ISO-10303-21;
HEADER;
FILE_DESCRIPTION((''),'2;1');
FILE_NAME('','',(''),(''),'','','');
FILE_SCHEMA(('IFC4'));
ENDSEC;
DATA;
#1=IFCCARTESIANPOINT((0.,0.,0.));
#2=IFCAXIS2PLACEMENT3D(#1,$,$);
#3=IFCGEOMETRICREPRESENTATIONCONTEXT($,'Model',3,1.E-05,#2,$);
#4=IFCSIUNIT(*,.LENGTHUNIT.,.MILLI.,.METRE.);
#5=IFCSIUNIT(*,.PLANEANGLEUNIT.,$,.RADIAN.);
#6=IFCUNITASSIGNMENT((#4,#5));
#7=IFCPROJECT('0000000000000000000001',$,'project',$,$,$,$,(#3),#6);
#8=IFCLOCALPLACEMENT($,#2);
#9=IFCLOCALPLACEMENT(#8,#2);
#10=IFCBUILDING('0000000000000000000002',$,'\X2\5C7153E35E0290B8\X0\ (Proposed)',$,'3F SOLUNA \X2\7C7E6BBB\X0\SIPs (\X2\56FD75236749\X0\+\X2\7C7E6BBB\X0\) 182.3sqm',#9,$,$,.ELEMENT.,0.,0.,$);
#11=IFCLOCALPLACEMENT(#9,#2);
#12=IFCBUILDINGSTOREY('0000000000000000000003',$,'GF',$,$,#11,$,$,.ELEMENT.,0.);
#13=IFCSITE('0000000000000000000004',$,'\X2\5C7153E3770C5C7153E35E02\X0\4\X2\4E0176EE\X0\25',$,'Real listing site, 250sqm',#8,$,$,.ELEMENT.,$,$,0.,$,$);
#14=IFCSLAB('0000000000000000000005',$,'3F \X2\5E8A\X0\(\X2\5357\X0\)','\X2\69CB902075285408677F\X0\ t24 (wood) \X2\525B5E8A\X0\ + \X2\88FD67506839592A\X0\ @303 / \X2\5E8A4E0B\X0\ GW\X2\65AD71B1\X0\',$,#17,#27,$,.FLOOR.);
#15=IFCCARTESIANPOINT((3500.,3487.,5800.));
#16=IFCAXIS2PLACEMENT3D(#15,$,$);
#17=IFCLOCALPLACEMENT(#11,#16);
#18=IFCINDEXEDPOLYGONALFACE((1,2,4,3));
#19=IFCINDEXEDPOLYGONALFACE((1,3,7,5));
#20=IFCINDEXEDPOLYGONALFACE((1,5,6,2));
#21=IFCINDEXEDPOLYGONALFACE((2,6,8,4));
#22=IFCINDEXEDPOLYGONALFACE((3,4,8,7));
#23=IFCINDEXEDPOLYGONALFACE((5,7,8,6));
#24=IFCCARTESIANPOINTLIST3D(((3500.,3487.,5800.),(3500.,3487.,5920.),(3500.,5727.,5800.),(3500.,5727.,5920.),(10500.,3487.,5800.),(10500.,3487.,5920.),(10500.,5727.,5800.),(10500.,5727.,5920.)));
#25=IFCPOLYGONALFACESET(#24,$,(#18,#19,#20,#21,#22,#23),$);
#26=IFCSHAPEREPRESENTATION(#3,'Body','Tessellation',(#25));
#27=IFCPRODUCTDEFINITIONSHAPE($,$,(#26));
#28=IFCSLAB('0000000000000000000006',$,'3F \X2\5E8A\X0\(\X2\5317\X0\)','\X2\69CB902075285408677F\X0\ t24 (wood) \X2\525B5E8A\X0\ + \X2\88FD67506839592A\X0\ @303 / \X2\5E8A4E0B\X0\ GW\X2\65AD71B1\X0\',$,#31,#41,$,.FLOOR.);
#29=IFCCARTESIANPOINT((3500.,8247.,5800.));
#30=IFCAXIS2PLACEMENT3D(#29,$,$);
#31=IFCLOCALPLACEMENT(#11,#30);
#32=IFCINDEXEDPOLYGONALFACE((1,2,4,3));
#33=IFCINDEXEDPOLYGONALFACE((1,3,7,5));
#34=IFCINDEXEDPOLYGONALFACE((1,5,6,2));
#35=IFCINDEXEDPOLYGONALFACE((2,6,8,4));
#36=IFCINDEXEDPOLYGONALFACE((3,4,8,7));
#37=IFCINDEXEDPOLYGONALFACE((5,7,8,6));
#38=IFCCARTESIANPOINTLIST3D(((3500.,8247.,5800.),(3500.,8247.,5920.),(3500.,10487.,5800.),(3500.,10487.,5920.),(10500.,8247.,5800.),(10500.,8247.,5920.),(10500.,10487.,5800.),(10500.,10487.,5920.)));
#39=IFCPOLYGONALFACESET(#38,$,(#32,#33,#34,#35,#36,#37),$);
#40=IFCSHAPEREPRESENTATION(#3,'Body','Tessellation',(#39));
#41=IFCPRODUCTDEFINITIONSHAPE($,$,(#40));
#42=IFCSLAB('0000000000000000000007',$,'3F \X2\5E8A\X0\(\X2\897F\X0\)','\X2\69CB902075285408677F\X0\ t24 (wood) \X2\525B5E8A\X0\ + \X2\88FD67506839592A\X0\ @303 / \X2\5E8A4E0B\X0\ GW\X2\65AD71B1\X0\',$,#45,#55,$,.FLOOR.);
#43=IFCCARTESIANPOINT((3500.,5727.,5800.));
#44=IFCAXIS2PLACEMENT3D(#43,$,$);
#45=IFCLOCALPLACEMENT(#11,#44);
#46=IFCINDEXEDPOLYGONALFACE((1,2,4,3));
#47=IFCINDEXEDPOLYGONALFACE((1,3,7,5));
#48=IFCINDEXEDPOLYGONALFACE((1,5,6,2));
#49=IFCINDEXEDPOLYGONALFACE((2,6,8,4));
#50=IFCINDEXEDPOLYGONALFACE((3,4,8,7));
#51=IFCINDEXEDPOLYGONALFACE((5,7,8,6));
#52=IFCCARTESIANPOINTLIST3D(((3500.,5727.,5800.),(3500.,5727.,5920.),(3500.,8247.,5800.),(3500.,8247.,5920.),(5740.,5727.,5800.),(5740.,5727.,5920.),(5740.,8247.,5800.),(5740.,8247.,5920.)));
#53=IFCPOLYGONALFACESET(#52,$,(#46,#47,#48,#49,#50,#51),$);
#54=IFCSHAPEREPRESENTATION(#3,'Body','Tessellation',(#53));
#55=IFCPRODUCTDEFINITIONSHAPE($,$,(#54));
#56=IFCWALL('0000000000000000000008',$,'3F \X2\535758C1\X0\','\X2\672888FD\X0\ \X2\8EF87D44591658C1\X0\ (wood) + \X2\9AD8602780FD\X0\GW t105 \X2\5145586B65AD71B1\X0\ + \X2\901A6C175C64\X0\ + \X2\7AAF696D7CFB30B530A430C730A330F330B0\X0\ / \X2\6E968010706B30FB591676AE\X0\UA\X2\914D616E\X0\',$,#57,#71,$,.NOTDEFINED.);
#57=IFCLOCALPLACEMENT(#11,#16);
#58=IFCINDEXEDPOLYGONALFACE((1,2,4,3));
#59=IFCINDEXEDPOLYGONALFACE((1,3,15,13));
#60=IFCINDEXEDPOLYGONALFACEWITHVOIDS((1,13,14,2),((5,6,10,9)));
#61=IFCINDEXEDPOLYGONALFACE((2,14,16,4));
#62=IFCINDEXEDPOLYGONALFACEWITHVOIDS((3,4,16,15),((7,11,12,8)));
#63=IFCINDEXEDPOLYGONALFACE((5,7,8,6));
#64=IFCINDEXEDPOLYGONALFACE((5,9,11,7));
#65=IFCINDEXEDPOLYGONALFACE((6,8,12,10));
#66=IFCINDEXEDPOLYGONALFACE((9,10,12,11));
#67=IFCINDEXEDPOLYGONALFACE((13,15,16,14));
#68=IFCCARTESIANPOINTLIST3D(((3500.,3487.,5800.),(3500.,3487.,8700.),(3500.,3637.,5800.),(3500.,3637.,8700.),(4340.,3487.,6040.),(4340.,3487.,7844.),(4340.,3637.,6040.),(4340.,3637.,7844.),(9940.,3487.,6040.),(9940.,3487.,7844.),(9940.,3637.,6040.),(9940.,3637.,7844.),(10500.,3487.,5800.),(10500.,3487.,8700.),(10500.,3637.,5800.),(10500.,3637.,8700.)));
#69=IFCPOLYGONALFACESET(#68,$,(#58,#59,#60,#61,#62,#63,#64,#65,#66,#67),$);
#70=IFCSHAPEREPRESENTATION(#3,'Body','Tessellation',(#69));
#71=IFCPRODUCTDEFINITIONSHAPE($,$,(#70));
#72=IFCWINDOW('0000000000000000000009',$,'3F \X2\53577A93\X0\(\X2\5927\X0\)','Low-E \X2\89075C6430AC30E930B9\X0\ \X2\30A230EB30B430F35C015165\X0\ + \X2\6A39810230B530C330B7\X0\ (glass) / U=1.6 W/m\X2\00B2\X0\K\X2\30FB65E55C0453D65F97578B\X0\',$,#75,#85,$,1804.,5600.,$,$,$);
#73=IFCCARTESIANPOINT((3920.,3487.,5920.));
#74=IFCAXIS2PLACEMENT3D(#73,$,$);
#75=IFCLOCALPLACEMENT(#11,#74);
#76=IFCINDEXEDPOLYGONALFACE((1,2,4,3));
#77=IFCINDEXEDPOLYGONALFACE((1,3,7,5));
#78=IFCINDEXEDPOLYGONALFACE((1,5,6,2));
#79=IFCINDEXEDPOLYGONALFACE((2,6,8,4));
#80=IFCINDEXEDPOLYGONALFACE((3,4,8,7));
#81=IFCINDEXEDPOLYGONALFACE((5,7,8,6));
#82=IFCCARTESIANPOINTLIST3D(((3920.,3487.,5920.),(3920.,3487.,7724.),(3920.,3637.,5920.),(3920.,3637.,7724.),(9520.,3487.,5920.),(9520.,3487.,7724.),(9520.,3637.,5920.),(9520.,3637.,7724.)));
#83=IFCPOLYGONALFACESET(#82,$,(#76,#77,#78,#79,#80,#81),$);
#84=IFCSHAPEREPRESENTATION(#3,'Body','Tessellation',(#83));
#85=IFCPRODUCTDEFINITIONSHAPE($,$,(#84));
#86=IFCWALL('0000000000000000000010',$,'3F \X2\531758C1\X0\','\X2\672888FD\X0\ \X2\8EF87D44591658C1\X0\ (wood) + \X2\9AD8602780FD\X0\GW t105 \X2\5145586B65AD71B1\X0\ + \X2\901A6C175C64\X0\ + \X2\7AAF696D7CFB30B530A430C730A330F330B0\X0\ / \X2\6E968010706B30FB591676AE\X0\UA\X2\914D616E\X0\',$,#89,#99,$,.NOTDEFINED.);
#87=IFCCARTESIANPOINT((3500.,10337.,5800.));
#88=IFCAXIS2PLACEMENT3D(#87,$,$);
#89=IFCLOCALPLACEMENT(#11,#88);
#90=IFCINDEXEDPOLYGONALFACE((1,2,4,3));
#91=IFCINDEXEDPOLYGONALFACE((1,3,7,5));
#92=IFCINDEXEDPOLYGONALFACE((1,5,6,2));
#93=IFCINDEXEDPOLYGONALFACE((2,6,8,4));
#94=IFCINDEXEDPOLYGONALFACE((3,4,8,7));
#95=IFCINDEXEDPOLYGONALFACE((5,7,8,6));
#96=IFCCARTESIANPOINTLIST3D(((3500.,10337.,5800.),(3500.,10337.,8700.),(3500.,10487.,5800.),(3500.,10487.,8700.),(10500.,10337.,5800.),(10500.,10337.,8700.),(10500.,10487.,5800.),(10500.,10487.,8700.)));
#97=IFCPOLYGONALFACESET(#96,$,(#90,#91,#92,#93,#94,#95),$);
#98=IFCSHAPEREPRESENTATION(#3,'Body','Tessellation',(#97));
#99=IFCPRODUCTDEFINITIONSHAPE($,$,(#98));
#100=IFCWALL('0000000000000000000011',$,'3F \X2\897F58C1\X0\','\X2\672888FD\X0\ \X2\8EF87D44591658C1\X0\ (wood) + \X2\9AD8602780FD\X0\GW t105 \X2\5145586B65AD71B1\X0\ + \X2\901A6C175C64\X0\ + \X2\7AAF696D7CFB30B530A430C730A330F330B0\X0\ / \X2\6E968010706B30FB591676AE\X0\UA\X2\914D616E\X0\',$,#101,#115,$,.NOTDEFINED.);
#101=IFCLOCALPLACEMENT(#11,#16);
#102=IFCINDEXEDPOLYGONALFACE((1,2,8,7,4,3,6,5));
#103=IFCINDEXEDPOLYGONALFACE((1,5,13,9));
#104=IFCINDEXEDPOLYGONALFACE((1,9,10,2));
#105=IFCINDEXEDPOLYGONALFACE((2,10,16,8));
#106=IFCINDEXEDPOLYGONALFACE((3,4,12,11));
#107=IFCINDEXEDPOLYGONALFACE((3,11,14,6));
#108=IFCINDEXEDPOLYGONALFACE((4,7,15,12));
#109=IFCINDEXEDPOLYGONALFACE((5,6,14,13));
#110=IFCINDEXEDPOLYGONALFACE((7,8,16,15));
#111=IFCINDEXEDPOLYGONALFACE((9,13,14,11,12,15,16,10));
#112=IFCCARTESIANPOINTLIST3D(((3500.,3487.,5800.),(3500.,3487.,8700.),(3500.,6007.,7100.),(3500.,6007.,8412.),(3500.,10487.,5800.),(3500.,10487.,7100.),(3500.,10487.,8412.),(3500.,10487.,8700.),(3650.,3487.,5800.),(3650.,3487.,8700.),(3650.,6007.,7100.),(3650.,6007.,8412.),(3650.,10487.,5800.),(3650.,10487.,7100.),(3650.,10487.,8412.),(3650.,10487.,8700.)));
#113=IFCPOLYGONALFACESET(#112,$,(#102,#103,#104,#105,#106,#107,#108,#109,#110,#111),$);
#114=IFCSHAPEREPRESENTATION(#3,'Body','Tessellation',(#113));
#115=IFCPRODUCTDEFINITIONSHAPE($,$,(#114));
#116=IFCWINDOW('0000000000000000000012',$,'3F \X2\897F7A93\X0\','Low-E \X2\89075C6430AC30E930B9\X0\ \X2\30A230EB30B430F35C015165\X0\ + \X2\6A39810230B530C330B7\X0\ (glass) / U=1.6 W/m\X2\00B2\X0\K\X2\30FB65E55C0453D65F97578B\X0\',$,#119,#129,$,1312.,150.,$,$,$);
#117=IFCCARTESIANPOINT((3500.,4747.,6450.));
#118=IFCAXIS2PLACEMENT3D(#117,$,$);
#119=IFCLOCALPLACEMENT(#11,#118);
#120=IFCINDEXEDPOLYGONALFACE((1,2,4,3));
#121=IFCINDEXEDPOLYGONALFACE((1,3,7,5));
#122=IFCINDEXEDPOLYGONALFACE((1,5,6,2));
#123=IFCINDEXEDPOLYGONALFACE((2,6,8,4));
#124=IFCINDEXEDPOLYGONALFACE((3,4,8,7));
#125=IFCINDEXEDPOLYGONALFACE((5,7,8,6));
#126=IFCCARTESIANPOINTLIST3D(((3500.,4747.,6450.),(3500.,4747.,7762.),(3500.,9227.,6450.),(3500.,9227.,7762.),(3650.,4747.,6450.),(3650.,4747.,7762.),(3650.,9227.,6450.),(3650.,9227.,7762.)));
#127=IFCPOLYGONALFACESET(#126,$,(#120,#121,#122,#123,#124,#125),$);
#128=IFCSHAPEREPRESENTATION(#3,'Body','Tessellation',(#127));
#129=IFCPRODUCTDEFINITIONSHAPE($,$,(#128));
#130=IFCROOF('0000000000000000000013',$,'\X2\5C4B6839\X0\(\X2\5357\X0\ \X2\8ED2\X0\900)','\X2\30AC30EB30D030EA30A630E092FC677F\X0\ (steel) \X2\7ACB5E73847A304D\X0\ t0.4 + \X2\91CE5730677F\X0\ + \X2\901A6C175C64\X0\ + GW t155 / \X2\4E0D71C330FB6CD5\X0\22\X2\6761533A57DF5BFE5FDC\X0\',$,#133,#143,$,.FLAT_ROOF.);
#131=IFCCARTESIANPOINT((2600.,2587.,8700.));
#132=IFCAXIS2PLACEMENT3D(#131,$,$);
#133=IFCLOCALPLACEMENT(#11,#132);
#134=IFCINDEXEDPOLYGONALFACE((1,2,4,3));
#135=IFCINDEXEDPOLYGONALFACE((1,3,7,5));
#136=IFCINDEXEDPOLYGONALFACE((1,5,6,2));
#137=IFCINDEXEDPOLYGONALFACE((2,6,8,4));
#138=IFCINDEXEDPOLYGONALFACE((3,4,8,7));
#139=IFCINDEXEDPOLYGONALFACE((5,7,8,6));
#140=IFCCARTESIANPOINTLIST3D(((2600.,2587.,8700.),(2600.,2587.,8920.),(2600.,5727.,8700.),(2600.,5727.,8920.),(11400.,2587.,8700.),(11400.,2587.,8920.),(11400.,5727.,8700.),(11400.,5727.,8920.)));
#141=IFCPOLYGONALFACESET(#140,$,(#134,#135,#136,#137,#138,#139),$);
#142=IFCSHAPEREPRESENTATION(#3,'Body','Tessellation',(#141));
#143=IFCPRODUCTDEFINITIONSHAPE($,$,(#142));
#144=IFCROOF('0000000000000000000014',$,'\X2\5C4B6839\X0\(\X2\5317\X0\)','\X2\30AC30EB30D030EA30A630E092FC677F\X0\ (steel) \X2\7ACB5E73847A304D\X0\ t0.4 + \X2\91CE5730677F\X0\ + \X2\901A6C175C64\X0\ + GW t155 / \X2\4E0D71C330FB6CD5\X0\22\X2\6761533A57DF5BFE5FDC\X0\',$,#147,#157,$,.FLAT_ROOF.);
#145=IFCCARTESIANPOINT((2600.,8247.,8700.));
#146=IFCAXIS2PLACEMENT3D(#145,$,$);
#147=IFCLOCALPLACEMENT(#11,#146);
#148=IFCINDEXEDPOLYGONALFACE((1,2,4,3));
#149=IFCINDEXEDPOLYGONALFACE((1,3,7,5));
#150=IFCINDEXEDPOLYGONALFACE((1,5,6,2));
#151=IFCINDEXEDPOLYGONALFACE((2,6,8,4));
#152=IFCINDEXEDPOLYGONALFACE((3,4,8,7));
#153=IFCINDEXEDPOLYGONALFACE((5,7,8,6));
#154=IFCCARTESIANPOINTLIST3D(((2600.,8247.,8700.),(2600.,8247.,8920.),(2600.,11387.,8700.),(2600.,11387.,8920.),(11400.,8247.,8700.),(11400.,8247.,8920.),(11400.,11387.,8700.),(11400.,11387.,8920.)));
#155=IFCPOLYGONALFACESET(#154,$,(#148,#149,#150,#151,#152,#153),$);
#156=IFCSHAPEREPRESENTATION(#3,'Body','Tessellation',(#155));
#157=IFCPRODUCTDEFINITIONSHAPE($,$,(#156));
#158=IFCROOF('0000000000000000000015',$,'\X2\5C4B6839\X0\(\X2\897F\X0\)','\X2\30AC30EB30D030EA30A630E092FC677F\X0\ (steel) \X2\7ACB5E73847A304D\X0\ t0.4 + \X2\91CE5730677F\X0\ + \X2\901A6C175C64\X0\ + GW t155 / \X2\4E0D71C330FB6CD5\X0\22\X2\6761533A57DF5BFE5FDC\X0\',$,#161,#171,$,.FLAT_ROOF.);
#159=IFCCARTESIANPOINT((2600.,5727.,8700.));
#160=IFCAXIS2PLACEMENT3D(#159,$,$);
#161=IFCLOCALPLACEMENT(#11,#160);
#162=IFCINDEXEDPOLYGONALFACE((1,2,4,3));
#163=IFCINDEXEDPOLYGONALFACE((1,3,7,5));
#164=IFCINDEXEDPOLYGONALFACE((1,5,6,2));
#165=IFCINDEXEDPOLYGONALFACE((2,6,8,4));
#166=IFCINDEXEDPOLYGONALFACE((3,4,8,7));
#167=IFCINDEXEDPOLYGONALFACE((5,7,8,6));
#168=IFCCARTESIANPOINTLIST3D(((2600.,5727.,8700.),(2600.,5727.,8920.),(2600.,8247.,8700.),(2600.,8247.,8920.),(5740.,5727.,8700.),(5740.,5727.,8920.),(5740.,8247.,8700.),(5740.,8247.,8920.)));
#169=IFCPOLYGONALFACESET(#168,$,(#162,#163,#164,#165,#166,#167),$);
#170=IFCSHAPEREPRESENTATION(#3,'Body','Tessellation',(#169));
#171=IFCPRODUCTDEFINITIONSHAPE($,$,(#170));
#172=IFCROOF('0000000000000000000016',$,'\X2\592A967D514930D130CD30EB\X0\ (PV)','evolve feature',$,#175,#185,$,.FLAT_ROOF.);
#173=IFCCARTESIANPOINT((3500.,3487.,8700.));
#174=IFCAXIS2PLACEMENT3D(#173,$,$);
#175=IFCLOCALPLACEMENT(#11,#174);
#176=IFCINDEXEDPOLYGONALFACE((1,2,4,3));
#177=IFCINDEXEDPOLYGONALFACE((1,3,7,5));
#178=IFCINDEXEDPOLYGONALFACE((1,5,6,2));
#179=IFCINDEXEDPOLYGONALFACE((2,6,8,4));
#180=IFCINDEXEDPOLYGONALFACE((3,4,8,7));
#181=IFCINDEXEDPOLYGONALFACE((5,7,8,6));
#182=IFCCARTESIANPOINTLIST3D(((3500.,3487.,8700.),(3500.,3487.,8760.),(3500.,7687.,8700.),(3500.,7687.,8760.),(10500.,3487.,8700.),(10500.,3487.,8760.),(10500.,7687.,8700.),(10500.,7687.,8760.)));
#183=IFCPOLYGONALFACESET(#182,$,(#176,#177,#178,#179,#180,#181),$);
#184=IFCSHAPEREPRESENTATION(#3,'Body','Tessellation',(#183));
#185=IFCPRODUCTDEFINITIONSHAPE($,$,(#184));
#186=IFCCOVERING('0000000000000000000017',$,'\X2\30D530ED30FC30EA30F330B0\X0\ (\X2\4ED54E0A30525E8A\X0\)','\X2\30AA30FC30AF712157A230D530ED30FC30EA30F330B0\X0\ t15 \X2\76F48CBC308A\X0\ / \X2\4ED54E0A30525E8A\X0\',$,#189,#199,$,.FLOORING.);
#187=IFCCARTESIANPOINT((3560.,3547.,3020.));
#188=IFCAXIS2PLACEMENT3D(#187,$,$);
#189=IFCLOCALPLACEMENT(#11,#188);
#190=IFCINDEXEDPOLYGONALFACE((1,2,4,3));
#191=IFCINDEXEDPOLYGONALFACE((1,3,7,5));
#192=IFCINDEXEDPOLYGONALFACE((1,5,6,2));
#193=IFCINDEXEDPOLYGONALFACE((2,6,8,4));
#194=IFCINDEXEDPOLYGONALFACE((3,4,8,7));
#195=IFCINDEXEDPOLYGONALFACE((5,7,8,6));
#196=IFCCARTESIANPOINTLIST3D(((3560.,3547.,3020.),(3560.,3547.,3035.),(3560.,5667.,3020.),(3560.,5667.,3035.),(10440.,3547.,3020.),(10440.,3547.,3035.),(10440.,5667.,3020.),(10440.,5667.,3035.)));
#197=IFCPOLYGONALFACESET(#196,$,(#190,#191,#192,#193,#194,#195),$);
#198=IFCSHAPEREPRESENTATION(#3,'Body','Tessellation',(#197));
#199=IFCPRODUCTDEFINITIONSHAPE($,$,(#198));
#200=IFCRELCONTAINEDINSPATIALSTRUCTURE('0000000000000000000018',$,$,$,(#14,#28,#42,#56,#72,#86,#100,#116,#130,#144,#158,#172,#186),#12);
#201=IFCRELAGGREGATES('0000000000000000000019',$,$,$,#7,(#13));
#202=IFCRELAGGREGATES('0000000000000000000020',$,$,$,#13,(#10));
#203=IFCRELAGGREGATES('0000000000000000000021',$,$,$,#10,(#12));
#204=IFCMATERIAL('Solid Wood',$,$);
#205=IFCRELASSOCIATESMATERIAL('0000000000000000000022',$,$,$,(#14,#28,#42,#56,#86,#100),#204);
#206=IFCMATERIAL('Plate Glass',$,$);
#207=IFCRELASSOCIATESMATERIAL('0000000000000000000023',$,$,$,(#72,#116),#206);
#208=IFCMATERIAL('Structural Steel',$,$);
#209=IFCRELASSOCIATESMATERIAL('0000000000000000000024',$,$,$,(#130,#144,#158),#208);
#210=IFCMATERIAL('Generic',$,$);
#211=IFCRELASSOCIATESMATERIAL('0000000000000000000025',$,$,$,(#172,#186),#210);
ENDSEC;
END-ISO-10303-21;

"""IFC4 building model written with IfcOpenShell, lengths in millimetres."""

from ifc_helpers import new_model, si_unit, frame, frame_2d, origin, place, context, project, spatial, rectangle, extrude, material, element, fill, save


model = new_model("IFC4")

# Units and contexts
model_context = context("Model", 3, precision=1e-05, world=origin())
ifc_project = project(units=[si_unit("LENGTHUNIT", "METRE", prefix="MILLI"), si_unit("PLANEANGLEUNIT", "RADIAN")], contexts=[model_context])

# Site, building, storey
site_placement = place(None, origin())
site = spatial("IfcSite", under=ifc_project, at=site_placement, Name="山口県山口市4丁目25", ObjectType="Real listing site, 250sqm", CompositionType="ELEMENT", RefElevation=0.0)
building_placement = place(site_placement, origin())
building = spatial("IfcBuilding", under=site, at=building_placement, Name="山口市邸 (Proposed)", ObjectType="3F SOLUNA 籾殻SIPs (国産杉+籾殻) 182.3sqm", CompositionType="ELEMENT", ElevationOfRefHeight=0.0, ElevationOfTerrain=0.0)
storey_placement = place(building_placement, origin())
storey = spatial("IfcBuildingStorey", under=building, at=storey_placement, Name="GF", CompositionType="ELEMENT", Elevation=0.0)

# Slabs
ifc_material_1 = material(Name="Solid Wood")
slab_1_placement = place(storey_placement, frame((3500.0, 3487.0, 5800.0)))
element("IfcSlab", 1, at=slab_1_placement, inside=storey, material=ifc_material_1, Name="3F 床(南)", Description="構造用合板 t24 (wood) 剛床 + 製材根太 @303 / 床下 GW断熱", PredefinedType="FLOOR", context=model_context, shape_type="SweptSolid", body=[
    extrude(rectangle(XDim=7000.0, YDim=2240.0, at=frame_2d((3500.0, 1120.0))), frame((3500.0, 3487.0, 5800.0)), (0.0, 0.0, 1.0), 120.0),
])
slab_2_placement = place(storey_placement, frame((3500.0, 8247.0, 5800.0)))
element("IfcSlab", 2, at=slab_2_placement, inside=storey, material=ifc_material_1, Name="3F 床(北)", Description="構造用合板 t24 (wood) 剛床 + 製材根太 @303 / 床下 GW断熱", PredefinedType="FLOOR", context=model_context, shape_type="SweptSolid", body=[
    extrude(rectangle(XDim=7000.0, YDim=2240.0, at=frame_2d((3500.0, 1120.0))), frame((3500.0, 8247.0, 5800.0)), (0.0, 0.0, 1.0), 120.0),
])
slab_3_placement = place(storey_placement, frame((3500.0, 5727.0, 5800.0)))
element("IfcSlab", 3, at=slab_3_placement, inside=storey, material=ifc_material_1, Name="3F 床(西)", Description="構造用合板 t24 (wood) 剛床 + 製材根太 @303 / 床下 GW断熱", PredefinedType="FLOOR", context=model_context, shape_type="SweptSolid", body=[
    extrude(rectangle(XDim=2240.0, YDim=2520.0, at=frame_2d((1120.0, 1260.0))), frame((3500.0, 5727.0, 5800.0)), (0.0, 0.0, 1.0), 120.0),
])

# Wall, opening, window
wall_1_placement = place(storey_placement, frame((3500.0, 3487.0, 5800.0)))
wall_1 = element("IfcWall", 4, at=wall_1_placement, inside=storey, material=ifc_material_1, Name="3F 南壁", Description="木製 軸組外壁 (wood) + 高性能GW t105 充填断熱 + 通気層 + 窯業系サイディング / 準耐火・外皮UA配慮", PredefinedType="NOTDEFINED", context=model_context, shape_type="SweptSolid", body=[
    extrude(rectangle(XDim=7000.0, YDim=150.0, at=frame_2d((3500.0, 75.0))), frame((3500.0, 3487.0, 5800.0)), (0.0, 0.0, 1.0), 2900.0),
])
opening_1_placement = place(storey_placement, frame((3920.0, 3487.0, 5920.0)))
opening_1 = element("IfcOpeningElement", 5, at=opening_1_placement, cuts=wall_1, PredefinedType="NOTDEFINED", context=model_context, shape_type="SweptSolid", body=[
    extrude(rectangle(XDim=5600.0, YDim=150.0, at=frame_2d((2800.0, 75.0))), frame((3920.0, 3487.0, 5920.0)), (0.0, 0.0, 1.0), 1804.0),
])
ifc_material_2 = material(Name="Plate Glass")
window_1_placement = place(storey_placement, frame((3920.0, 3487.0, 5920.0)))
window_1 = element("IfcWindow", 6, at=window_1_placement, inside=storey, material=ifc_material_2, Name="3F 南窓(大)", Description="Low-E 複層ガラス アルゴン封入 + 樹脂サッシ (glass) / U=1.6 W/m²K・日射取得型", OverallHeight=1804.0, OverallWidth=5600.0, context=model_context, shape_type="SweptSolid", body=[
    extrude(rectangle(XDim=5600.0, YDim=150.0, at=frame_2d((2800.0, 75.0))), frame((3920.0, 3487.0, 5920.0)), (0.0, 0.0, 1.0), 1804.0),
])
fill(opening_1, window_1)

# Wall
wall_2_placement = place(storey_placement, frame((3500.0, 10337.0, 5800.0)))
element("IfcWall", 7, at=wall_2_placement, inside=storey, material=ifc_material_1, Name="3F 北壁", Description="木製 軸組外壁 (wood) + 高性能GW t105 充填断熱 + 通気層 + 窯業系サイディング / 準耐火・外皮UA配慮", PredefinedType="NOTDEFINED", context=model_context, shape_type="SweptSolid", body=[
    extrude(rectangle(XDim=7000.0, YDim=150.0, at=frame_2d((3500.0, 75.0))), frame((3500.0, 10337.0, 5800.0)), (0.0, 0.0, 1.0), 2900.0),
])

# Wall, opening, window
wall_3_placement = place(storey_placement, frame((3500.0, 3487.0, 5800.0)))
wall_3 = element("IfcWall", 8, at=wall_3_placement, inside=storey, material=ifc_material_1, Name="3F 西壁", Description="木製 軸組外壁 (wood) + 高性能GW t105 充填断熱 + 通気層 + 窯業系サイディング / 準耐火・外皮UA配慮", PredefinedType="NOTDEFINED", context=model_context, shape_type="SweptSolid", body=[
    extrude(rectangle(XDim=150.0, YDim=7000.0, at=frame_2d((75.0, 3500.0))), frame((3500.0, 3487.0, 5800.0)), (0.0, 0.0, 1.0), 2900.0),
])
opening_2_placement = place(storey_placement, frame((3500.0, 4747.0, 6450.0)))
opening_2 = element("IfcOpeningElement", 9, at=opening_2_placement, cuts=wall_3, PredefinedType="NOTDEFINED", context=model_context, shape_type="SweptSolid", body=[
    extrude(rectangle(XDim=150.0, YDim=4480.0, at=frame_2d((75.0, 2240.0))), frame((3500.0, 4747.0, 6450.0)), (0.0, 0.0, 1.0), 1312.0),
])
window_2_placement = place(storey_placement, frame((3500.0, 4747.0, 6450.0)))
window_2 = element("IfcWindow", 10, at=window_2_placement, inside=storey, material=ifc_material_2, Name="3F 西窓", Description="Low-E 複層ガラス アルゴン封入 + 樹脂サッシ (glass) / U=1.6 W/m²K・日射取得型", OverallHeight=1312.0, OverallWidth=150.0, context=model_context, shape_type="SweptSolid", body=[
    extrude(rectangle(XDim=150.0, YDim=4480.0, at=frame_2d((75.0, 2240.0))), frame((3500.0, 4747.0, 6450.0)), (0.0, 0.0, 1.0), 1312.0),
])
fill(opening_2, window_2)

# Roofs
ifc_material_3 = material(Name="Structural Steel")
roof_1_placement = place(storey_placement, frame((2600.0, 2587.0, 8700.0)))
element("IfcRoof", 11, at=roof_1_placement, inside=storey, material=ifc_material_3, Name="屋根(南 軒900)", Description="ガルバリウム鋼板 (steel) 立平葺き t0.4 + 野地板 + 通気層 + GW t155 / 不燃・法22条区域対応", PredefinedType="FLAT_ROOF", context=model_context, shape_type="SweptSolid", body=[
    extrude(rectangle(XDim=8800.0, YDim=3140.0, at=frame_2d((4400.0, 1570.0))), frame((2600.0, 2587.0, 8700.0)), (0.0, 0.0, 1.0), 220.0),
])
roof_2_placement = place(storey_placement, frame((2600.0, 8247.0, 8700.0)))
element("IfcRoof", 12, at=roof_2_placement, inside=storey, material=ifc_material_3, Name="屋根(北)", Description="ガルバリウム鋼板 (steel) 立平葺き t0.4 + 野地板 + 通気層 + GW t155 / 不燃・法22条区域対応", PredefinedType="FLAT_ROOF", context=model_context, shape_type="SweptSolid", body=[
    extrude(rectangle(XDim=8800.0, YDim=3140.0, at=frame_2d((4400.0, 1570.0))), frame((2600.0, 8247.0, 8700.0)), (0.0, 0.0, 1.0), 220.0),
])
roof_3_placement = place(storey_placement, frame((2600.0, 5727.0, 8700.0)))
element("IfcRoof", 13, at=roof_3_placement, inside=storey, material=ifc_material_3, Name="屋根(西)", Description="ガルバリウム鋼板 (steel) 立平葺き t0.4 + 野地板 + 通気層 + GW t155 / 不燃・法22条区域対応", PredefinedType="FLAT_ROOF", context=model_context, shape_type="SweptSolid", body=[
    extrude(rectangle(XDim=3140.0, YDim=2520.0, at=frame_2d((1570.0, 1260.0))), frame((2600.0, 5727.0, 8700.0)), (0.0, 0.0, 1.0), 220.0),
])
ifc_material_4 = material(Name="Generic")
roof_4_placement = place(storey_placement, frame((3500.0, 3487.0, 8700.0)))
element("IfcRoof", 14, at=roof_4_placement, inside=storey, material=ifc_material_4, Name="太陽光パネル (PV)", Description="evolve feature", PredefinedType="FLAT_ROOF", context=model_context, shape_type="SweptSolid", body=[
    extrude(rectangle(XDim=7000.0, YDim=4200.0, at=frame_2d((3500.0, 2100.0))), frame((3500.0, 3487.0, 8700.0)), (0.0, 0.0, 1.0), 60.0),
])

# Covering
covering_1_placement = place(storey_placement, frame((3560.0, 3547.0, 3020.0)))
element("IfcCovering", 15, at=covering_1_placement, inside=storey, material=ifc_material_4, Name="フローリング (仕上げ床)", Description="オーク無垢フローリング t15 直貼り / 仕上げ床", PredefinedType="FLOORING", context=model_context, shape_type="SweptSolid", body=[
    extrude(rectangle(XDim=6880.0, YDim=2120.0, at=frame_2d((3440.0, 1060.0))), frame((3560.0, 3547.0, 3020.0)), (0.0, 0.0, 1.0), 15.0),
])

save(model, "model.ifc")
